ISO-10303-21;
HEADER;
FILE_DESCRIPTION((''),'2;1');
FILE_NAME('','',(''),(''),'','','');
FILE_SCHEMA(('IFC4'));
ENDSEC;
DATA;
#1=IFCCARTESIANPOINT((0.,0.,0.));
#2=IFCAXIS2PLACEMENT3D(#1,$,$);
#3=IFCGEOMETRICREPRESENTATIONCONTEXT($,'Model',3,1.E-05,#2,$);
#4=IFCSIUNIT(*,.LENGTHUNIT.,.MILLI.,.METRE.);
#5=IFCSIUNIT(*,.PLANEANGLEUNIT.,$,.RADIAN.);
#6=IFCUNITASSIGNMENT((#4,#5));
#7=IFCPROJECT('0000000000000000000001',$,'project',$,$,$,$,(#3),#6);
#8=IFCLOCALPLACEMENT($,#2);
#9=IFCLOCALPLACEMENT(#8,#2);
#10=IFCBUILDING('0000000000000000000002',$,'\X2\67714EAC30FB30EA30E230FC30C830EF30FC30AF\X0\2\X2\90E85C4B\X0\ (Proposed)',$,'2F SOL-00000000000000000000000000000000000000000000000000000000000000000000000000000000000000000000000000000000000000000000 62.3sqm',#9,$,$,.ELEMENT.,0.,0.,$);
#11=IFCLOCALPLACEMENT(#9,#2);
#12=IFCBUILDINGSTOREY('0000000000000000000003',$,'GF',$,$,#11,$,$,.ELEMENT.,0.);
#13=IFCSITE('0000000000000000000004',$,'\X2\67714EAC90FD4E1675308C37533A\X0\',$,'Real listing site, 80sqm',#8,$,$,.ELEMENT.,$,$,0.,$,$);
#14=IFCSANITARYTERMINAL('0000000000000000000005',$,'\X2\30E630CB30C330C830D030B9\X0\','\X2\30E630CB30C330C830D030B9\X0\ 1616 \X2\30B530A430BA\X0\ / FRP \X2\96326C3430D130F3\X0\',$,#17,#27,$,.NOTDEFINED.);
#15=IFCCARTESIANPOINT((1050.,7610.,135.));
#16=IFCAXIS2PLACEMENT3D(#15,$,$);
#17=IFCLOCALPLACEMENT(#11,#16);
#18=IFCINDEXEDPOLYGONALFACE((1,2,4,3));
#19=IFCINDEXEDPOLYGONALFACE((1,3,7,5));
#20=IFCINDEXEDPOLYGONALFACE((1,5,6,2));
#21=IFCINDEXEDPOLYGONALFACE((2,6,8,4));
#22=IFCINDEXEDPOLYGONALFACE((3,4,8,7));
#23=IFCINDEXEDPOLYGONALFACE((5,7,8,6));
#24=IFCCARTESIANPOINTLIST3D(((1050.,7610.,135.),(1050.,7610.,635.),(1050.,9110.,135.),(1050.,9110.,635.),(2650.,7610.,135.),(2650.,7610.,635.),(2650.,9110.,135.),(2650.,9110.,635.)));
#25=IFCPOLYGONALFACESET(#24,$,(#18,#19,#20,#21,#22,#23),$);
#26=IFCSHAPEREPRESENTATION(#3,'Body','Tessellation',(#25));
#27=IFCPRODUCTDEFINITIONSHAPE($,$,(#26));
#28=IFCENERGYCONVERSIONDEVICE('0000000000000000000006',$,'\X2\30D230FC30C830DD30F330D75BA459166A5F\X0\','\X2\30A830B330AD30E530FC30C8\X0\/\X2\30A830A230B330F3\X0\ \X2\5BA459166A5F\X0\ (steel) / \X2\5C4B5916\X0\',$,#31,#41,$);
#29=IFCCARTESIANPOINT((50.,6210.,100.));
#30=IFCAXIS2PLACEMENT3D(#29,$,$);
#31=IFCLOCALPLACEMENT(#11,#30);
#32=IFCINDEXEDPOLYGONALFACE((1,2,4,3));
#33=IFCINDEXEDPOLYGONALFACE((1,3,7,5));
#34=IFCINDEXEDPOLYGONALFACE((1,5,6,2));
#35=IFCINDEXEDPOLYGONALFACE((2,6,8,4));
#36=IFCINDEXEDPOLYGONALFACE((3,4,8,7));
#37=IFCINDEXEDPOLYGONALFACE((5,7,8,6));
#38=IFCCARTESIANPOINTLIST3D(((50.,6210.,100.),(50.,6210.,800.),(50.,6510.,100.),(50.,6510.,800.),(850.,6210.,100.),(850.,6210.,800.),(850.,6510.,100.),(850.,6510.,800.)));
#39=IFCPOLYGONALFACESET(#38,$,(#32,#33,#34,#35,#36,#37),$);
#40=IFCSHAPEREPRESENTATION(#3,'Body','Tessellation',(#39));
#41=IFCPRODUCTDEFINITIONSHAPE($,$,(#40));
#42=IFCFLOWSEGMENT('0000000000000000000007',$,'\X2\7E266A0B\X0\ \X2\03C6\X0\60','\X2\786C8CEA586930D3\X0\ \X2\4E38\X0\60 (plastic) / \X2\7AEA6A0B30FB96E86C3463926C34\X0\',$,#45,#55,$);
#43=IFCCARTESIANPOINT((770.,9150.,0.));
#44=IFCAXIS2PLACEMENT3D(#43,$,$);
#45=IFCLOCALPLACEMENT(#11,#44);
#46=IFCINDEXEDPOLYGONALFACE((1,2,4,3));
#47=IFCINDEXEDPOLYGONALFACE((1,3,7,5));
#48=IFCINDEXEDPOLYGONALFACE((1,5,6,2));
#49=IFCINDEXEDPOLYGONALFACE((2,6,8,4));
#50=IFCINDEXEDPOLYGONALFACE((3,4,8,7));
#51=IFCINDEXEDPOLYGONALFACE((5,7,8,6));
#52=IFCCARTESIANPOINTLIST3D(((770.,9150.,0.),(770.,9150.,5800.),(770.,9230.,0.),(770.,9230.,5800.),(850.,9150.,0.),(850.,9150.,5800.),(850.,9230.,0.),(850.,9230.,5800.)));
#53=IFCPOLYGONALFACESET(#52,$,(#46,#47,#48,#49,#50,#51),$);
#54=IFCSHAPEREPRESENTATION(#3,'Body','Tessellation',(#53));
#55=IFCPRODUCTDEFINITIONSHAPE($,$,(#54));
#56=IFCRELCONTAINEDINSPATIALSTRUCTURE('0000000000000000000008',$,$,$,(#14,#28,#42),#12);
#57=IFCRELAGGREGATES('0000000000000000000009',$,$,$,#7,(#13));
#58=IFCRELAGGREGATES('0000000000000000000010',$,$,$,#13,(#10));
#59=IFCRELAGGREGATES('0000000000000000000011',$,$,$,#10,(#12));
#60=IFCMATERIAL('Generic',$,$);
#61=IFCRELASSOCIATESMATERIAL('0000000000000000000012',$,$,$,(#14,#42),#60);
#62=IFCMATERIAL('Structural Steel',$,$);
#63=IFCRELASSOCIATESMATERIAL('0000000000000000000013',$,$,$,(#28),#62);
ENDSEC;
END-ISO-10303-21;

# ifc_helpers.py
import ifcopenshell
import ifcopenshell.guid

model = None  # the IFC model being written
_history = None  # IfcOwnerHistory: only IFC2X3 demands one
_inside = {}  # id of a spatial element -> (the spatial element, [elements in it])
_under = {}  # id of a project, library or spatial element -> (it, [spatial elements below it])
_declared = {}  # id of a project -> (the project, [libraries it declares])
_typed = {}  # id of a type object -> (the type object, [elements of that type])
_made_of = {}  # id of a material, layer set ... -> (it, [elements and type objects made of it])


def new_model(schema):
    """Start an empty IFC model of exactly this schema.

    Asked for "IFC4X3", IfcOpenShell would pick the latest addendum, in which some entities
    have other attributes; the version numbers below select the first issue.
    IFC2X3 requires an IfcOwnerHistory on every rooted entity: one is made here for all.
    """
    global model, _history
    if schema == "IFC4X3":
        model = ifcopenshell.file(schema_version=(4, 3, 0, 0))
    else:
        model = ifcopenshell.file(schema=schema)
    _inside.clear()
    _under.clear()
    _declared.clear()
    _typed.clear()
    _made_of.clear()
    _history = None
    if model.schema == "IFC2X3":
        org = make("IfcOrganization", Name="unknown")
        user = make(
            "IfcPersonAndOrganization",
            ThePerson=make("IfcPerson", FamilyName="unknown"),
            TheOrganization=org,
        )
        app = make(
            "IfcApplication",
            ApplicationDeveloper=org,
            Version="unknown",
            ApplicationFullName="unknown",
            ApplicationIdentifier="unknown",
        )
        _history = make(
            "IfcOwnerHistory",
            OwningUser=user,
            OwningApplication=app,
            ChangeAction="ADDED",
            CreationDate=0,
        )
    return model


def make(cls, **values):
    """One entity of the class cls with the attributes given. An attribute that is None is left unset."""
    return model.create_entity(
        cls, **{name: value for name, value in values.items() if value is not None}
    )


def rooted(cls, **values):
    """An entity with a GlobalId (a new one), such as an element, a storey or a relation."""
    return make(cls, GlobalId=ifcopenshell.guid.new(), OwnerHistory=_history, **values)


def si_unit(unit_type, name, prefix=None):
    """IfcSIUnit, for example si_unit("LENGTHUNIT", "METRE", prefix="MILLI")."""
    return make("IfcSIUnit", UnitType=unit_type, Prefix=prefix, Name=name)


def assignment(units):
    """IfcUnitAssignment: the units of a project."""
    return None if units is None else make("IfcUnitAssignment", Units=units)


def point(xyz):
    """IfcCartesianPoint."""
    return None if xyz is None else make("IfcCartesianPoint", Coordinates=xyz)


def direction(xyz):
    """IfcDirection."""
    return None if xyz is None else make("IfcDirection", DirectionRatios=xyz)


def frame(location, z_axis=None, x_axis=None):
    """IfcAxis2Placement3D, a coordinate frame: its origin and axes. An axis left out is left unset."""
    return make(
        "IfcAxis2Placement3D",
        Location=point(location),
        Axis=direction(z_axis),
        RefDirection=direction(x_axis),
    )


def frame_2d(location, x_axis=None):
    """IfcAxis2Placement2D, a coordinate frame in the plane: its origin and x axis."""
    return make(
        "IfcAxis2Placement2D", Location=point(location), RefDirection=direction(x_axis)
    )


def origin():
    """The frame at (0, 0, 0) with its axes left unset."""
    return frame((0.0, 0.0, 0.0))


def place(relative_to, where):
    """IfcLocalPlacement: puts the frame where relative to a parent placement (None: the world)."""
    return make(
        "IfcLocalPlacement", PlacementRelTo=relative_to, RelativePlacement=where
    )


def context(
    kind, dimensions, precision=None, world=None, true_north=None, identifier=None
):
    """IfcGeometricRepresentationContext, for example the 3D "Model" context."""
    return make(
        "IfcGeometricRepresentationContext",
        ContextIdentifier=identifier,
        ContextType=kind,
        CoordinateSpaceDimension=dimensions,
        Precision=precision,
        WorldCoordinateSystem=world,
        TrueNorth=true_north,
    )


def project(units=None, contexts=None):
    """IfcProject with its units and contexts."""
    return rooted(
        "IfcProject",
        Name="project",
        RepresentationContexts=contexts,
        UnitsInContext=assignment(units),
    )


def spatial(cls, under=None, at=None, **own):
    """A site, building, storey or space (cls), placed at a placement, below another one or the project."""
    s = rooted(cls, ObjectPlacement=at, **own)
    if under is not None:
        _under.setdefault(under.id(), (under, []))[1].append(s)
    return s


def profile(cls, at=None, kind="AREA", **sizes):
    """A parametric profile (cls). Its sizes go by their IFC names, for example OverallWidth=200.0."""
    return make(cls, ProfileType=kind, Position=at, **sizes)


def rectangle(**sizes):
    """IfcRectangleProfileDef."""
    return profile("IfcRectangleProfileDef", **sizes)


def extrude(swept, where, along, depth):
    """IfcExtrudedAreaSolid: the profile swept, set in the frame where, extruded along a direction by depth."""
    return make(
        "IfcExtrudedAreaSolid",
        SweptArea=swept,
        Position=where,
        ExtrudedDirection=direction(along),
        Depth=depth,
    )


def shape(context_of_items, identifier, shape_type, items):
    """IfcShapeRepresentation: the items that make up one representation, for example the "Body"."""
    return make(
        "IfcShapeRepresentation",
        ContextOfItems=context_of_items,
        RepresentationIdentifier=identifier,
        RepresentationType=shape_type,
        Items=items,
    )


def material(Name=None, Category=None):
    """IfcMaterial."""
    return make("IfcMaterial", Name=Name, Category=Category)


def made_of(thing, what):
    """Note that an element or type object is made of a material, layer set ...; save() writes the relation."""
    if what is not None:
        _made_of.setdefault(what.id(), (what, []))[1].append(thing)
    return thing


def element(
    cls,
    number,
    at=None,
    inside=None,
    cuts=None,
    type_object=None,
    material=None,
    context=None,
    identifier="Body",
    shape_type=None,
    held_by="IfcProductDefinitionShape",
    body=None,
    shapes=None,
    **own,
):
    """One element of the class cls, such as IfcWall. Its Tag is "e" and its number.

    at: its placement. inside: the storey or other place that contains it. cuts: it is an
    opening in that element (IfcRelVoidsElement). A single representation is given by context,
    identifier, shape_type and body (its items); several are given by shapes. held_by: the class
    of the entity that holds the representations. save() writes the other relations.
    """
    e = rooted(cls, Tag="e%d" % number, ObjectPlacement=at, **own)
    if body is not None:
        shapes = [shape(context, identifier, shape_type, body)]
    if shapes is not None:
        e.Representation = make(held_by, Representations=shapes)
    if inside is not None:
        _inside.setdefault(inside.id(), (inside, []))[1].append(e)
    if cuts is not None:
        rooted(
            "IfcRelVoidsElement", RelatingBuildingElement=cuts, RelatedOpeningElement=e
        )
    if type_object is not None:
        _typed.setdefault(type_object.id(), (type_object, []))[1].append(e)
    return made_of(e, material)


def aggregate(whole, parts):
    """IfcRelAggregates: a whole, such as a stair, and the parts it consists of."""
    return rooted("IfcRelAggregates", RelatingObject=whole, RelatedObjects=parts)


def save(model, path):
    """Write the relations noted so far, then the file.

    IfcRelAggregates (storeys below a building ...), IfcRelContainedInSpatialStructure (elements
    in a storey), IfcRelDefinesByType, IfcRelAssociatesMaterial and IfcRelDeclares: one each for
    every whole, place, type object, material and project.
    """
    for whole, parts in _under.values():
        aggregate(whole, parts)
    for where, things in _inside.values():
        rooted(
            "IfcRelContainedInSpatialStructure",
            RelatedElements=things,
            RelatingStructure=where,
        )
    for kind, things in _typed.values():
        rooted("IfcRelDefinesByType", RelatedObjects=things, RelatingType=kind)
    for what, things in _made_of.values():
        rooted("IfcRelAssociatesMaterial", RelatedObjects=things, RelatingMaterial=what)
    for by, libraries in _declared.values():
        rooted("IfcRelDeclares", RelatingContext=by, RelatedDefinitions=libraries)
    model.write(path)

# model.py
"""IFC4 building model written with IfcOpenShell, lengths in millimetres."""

from ifc_helpers import new_model, si_unit, frame, frame_2d, origin, place, context, project, spatial, rectangle, extrude, material, element, save


model = new_model("IFC4")

# Units and contexts
model_context = context("Model", 3, precision=1e-05, world=origin())
ifc_project = project(units=[si_unit("LENGTHUNIT", "METRE", prefix="MILLI"), si_unit("PLANEANGLEUNIT", "RADIAN")], contexts=[model_context])

# Site, building, storey
site_placement = place(None, origin())
site = spatial("IfcSite", under=ifc_project, at=site_placement, Name="東京都世田谷区", ObjectType="Real listing site, 80sqm", CompositionType="ELEMENT", RefElevation=0.0)
building_placement = place(site_placement, origin())
building = spatial("IfcBuilding", under=site, at=building_placement, Name="東京・リモートワーク2部屋 (Proposed)", ObjectType="2F SOL-00000000000000000000000000000000000000000000000000000000000000000000000000000000000000000000000000000000000000000000 62.3sqm", CompositionType="ELEMENT", ElevationOfRefHeight=0.0, ElevationOfTerrain=0.0)
storey_placement = place(building_placement, origin())
storey = spatial("IfcBuildingStorey", under=building, at=storey_placement, Name="GF", CompositionType="ELEMENT", Elevation=0.0)

# Shared definitions
ifc_material_1 = material(Name="Generic")

# Sanitary terminal
sanitary_terminal_placement = place(storey_placement, frame((1050.0, 7610.0, 135.0)))
element("IfcSanitaryTerminal", 1, at=sanitary_terminal_placement, inside=storey, material=ifc_material_1, Name="ユニットバス", Description="ユニットバス 1616 サイズ / FRP 防水パン", PredefinedType="NOTDEFINED", context=model_context, shape_type="SweptSolid", body=[
    extrude(rectangle(XDim=1600.0, YDim=1500.0, at=frame_2d((800.0, 750.0))), frame((1050.0, 7610.0, 135.0)), (0.0, 0.0, 1.0), 500.0),
])

# Energy conversion device
ifc_material_2 = material(Name="Structural Steel")
energy_conversion_device_placement = place(storey_placement, frame((50.0, 6210.0, 100.0)))
element("IfcEnergyConversionDevice", 2, at=energy_conversion_device_placement, inside=storey, material=ifc_material_2, Name="ヒートポンプ室外機", Description="エコキュート/エアコン 室外機 (steel) / 屋外", context=model_context, shape_type="SweptSolid", body=[
    extrude(rectangle(XDim=800.0, YDim=300.0, at=frame_2d((400.0, 150.0))), frame((50.0, 6210.0, 100.0)), (0.0, 0.0, 1.0), 700.0),
])

# Flow segment
flow_segment_placement = place(storey_placement, frame((770.0, 9150.0, 0.0)))
element("IfcFlowSegment", 3, at=flow_segment_placement, inside=storey, material=ifc_material_1, Name="縦樋 φ60", Description="硬質塩ビ 丸60 (plastic) / 竪樋・雨水排水", context=model_context, shape_type="SweptSolid", body=[
    extrude(rectangle(XDim=80.0, YDim=80.0, at=frame_2d((40.0, 40.0))), frame((770.0, 9150.0, 0.0)), (0.0, 0.0, 1.0), 5800.0),
])

save(model, "model.ifc")
